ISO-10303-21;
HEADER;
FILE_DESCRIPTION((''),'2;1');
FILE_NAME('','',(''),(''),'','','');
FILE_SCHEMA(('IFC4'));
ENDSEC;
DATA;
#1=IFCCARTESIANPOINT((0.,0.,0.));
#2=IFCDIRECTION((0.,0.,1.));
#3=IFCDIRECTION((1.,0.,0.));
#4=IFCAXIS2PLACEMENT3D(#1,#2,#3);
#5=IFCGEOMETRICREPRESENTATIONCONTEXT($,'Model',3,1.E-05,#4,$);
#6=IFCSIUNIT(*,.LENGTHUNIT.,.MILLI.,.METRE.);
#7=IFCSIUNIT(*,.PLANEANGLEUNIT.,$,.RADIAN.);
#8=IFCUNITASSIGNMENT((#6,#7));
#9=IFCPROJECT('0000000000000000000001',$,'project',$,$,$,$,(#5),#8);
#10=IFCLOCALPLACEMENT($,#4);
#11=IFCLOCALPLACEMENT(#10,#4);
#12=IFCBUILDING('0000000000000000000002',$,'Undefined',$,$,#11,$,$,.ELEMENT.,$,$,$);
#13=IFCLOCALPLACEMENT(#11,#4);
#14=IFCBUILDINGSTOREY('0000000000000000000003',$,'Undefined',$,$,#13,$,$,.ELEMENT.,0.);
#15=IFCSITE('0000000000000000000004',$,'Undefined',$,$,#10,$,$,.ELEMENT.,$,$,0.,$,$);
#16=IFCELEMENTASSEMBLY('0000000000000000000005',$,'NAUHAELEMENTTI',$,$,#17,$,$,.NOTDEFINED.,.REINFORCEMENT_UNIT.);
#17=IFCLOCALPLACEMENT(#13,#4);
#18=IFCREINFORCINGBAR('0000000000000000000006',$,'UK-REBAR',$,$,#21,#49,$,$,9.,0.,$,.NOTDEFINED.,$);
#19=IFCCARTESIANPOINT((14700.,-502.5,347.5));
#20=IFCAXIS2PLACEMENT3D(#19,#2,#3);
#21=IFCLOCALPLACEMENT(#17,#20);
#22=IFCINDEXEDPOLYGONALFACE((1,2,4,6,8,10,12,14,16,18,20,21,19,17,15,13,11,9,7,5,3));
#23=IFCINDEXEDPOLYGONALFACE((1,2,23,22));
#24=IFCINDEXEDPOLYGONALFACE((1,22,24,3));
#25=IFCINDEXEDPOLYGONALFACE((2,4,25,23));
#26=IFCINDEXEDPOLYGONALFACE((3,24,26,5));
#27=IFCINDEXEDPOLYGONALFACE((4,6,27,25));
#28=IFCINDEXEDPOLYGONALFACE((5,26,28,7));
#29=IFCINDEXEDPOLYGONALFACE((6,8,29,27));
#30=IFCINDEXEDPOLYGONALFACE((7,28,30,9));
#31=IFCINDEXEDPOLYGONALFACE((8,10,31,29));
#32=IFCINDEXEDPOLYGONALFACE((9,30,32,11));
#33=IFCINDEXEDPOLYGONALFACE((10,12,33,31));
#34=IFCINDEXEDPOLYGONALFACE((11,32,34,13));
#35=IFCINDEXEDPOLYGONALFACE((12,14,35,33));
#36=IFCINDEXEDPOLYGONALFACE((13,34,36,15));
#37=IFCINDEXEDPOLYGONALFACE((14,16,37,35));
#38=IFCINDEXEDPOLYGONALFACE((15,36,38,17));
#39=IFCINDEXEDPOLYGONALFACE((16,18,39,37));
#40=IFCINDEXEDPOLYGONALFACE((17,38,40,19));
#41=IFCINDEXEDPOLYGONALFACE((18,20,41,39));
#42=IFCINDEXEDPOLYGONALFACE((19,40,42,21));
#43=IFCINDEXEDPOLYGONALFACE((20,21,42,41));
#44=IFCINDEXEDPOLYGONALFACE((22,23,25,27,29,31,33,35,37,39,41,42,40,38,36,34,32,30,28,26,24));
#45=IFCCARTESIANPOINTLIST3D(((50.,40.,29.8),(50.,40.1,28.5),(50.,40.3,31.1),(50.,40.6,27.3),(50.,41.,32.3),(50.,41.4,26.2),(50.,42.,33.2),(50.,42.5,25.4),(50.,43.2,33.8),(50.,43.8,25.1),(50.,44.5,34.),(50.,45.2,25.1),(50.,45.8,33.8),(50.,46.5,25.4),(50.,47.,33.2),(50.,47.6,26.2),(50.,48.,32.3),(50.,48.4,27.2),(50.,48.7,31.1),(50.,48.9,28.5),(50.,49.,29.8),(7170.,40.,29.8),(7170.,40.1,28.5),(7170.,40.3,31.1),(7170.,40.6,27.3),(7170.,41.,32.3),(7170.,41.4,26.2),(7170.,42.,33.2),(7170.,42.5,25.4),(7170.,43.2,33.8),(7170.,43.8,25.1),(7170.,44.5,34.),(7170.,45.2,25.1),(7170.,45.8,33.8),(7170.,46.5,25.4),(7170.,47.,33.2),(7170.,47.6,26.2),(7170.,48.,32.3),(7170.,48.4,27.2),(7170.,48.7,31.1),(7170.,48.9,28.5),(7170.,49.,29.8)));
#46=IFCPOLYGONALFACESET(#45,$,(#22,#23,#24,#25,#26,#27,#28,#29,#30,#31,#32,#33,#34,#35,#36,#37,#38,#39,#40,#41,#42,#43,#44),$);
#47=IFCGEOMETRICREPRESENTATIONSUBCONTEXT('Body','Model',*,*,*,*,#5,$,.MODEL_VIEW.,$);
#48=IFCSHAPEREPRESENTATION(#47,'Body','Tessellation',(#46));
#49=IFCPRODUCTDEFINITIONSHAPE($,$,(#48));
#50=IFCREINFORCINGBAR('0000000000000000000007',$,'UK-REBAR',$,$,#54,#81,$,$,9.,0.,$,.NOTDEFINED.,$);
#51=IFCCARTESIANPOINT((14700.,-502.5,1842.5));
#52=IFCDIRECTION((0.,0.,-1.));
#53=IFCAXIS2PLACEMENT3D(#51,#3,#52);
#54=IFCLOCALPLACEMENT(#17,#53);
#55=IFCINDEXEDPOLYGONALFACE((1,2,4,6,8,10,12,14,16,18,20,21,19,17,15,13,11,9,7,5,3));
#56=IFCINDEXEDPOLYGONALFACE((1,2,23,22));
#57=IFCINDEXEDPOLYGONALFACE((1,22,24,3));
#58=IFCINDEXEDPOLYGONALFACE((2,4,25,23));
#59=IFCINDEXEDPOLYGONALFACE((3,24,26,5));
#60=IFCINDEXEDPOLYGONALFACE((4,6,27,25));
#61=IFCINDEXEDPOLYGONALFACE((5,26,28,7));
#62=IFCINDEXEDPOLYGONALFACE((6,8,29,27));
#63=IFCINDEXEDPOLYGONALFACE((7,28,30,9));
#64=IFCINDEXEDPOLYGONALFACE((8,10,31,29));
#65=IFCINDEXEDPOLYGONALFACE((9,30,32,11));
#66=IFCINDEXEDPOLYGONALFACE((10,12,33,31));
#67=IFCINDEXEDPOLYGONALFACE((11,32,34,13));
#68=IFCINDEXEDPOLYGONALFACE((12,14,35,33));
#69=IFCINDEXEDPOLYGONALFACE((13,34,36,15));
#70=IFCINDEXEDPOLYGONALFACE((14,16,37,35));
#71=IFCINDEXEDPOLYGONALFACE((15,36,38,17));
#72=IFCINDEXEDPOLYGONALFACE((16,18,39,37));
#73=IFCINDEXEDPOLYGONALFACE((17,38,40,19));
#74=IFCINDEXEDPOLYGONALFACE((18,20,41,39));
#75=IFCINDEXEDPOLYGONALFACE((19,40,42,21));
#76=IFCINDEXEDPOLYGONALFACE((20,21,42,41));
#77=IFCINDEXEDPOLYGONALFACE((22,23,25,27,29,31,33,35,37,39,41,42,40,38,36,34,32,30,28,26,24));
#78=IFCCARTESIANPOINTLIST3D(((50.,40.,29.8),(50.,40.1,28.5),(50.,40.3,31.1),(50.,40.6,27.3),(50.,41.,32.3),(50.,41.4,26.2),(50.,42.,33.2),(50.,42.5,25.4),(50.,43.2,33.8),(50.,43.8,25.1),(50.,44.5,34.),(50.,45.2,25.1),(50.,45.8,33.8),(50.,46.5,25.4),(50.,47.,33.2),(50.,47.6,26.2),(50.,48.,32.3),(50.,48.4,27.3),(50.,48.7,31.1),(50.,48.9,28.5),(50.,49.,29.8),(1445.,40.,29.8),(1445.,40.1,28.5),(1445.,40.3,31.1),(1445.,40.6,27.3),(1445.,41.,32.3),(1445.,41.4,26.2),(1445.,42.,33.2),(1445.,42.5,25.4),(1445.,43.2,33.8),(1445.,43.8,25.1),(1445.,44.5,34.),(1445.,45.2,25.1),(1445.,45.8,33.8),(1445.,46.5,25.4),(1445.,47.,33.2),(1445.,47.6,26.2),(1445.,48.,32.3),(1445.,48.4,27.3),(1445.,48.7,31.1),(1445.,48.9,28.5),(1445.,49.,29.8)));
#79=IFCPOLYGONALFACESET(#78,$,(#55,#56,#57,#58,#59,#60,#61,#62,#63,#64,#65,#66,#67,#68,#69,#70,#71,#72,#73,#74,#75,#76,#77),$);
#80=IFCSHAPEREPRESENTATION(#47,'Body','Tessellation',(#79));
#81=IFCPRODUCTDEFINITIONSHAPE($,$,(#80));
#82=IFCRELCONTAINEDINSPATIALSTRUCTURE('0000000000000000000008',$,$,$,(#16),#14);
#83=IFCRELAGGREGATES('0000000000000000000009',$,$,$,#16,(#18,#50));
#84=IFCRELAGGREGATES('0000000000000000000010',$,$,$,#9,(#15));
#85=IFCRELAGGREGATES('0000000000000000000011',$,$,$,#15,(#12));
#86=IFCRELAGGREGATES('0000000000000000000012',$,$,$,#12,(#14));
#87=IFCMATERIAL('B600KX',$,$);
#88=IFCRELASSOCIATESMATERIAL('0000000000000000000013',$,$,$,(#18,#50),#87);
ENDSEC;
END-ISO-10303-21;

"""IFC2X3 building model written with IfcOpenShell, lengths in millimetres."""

from ifc_helpers import new_model, entity, si_unit, frame, origin_with_axes, place, context, subcontext, project, spatial, source, transform, mapped, material, element, aggregate, save


model = new_model("IFC2X3")

# Units and contexts
model_context = context("Model", 3, precision=1e-05, world=origin_with_axes())
body_context = subcontext(model_context, "Body", "Model", "MODEL_VIEW")
ifc_project = project(units=[si_unit("LENGTHUNIT", "METRE", prefix="MILLI"), si_unit("PLANEANGLEUNIT", "RADIAN")], contexts=[model_context])

# Site, building, storey
site_placement = place(None, origin_with_axes())
site = spatial("IfcSite", under=ifc_project, at=site_placement, Name="Undefined", CompositionType="ELEMENT", RefElevation=0.0)
building_placement = place(site_placement, origin_with_axes())
building = spatial("IfcBuilding", under=site, at=building_placement, Name="Undefined", CompositionType="ELEMENT")
storey_placement = place(building_placement, origin_with_axes())
storey = spatial("IfcBuildingStorey", under=building, at=storey_placement, Name="Undefined", CompositionType="ELEMENT", Elevation=0.0)

# Element assembly
assembly_1_placement = place(storey_placement, origin_with_axes())
assembly_1 = element("IfcElementAssembly", 1, at=assembly_1_placement, inside=storey, Name="NAUHAELEMENTTI", AssemblyPlace="NOTDEFINED", PredefinedType="REINFORCEMENT_UNIT")

# Reinforcing bars
ifc_material_1 = material(Name="B600KX")
shared_shape_1 = source(origin_with_axes(), body_context, "Body", "AdvancedSweptSolid", [
    entity("IfcSweptDiskSolid", entity("IfcTrimmedCurve", entity("IfcLine", entity("IfcCartesianPoint", [0.0, 0.0, 0.0]), entity("IfcVector", entity("IfcDirection", [1.0, 0.0, 0.0]), 1.0)), [entity("IfcParameterValue", 0.0)], [entity("IfcParameterValue", 7119.9998)], True, "PARAMETER"), 4.5, None, 0.0, 7120.0),
])
reinforcing_bar_1_placement = place(assembly_1_placement, frame((14700.0, -502.5, 347.5), z_axis=(0.0, 0.0, 1.0), x_axis=(1.0, 0.0, 0.0)))
reinforcing_bar_1 = element("IfcReinforcingBar", 2, at=reinforcing_bar_1_placement, material=ifc_material_1, Name="UK-REBAR", BarRole="NOTDEFINED", CrossSectionArea=0.0, NominalDiameter=9.0, context=body_context, shape_type="MappedRepresentation", body=[
    mapped(shared_shape_1, transform((50.0, 44.5, 29.5))),
])
shared_shape_2 = source(origin_with_axes(), body_context, "Body", "AdvancedSweptSolid", [
    entity("IfcSweptDiskSolid", entity("IfcTrimmedCurve", entity("IfcLine", entity("IfcCartesianPoint", [0.0, 0.0, 0.0]), entity("IfcVector", entity("IfcDirection", [1.0, 0.0, 0.0]), 1.0)), [entity("IfcParameterValue", 0.0)], [entity("IfcParameterValue", 1395.0)], True, "PARAMETER"), 4.5, None, 0.0, 1395.0),
])
reinforcing_bar_2_placement = place(assembly_1_placement, frame((14700.0, -502.5, 1842.5), z_axis=(1.0, 0.0, 0.0), x_axis=(0.0, 0.0, -1.0)))
reinforcing_bar_2 = element("IfcReinforcingBar", 3, at=reinforcing_bar_2_placement, material=ifc_material_1, Name="UK-REBAR", BarRole="NOTDEFINED", CrossSectionArea=0.0, NominalDiameter=9.0, context=body_context, shape_type="MappedRepresentation", body=[
    mapped(shared_shape_2, transform((50.0, 44.5, 29.5))),
])
aggregate(assembly_1, [reinforcing_bar_1, reinforcing_bar_2])

save(model, "model.ifc")
